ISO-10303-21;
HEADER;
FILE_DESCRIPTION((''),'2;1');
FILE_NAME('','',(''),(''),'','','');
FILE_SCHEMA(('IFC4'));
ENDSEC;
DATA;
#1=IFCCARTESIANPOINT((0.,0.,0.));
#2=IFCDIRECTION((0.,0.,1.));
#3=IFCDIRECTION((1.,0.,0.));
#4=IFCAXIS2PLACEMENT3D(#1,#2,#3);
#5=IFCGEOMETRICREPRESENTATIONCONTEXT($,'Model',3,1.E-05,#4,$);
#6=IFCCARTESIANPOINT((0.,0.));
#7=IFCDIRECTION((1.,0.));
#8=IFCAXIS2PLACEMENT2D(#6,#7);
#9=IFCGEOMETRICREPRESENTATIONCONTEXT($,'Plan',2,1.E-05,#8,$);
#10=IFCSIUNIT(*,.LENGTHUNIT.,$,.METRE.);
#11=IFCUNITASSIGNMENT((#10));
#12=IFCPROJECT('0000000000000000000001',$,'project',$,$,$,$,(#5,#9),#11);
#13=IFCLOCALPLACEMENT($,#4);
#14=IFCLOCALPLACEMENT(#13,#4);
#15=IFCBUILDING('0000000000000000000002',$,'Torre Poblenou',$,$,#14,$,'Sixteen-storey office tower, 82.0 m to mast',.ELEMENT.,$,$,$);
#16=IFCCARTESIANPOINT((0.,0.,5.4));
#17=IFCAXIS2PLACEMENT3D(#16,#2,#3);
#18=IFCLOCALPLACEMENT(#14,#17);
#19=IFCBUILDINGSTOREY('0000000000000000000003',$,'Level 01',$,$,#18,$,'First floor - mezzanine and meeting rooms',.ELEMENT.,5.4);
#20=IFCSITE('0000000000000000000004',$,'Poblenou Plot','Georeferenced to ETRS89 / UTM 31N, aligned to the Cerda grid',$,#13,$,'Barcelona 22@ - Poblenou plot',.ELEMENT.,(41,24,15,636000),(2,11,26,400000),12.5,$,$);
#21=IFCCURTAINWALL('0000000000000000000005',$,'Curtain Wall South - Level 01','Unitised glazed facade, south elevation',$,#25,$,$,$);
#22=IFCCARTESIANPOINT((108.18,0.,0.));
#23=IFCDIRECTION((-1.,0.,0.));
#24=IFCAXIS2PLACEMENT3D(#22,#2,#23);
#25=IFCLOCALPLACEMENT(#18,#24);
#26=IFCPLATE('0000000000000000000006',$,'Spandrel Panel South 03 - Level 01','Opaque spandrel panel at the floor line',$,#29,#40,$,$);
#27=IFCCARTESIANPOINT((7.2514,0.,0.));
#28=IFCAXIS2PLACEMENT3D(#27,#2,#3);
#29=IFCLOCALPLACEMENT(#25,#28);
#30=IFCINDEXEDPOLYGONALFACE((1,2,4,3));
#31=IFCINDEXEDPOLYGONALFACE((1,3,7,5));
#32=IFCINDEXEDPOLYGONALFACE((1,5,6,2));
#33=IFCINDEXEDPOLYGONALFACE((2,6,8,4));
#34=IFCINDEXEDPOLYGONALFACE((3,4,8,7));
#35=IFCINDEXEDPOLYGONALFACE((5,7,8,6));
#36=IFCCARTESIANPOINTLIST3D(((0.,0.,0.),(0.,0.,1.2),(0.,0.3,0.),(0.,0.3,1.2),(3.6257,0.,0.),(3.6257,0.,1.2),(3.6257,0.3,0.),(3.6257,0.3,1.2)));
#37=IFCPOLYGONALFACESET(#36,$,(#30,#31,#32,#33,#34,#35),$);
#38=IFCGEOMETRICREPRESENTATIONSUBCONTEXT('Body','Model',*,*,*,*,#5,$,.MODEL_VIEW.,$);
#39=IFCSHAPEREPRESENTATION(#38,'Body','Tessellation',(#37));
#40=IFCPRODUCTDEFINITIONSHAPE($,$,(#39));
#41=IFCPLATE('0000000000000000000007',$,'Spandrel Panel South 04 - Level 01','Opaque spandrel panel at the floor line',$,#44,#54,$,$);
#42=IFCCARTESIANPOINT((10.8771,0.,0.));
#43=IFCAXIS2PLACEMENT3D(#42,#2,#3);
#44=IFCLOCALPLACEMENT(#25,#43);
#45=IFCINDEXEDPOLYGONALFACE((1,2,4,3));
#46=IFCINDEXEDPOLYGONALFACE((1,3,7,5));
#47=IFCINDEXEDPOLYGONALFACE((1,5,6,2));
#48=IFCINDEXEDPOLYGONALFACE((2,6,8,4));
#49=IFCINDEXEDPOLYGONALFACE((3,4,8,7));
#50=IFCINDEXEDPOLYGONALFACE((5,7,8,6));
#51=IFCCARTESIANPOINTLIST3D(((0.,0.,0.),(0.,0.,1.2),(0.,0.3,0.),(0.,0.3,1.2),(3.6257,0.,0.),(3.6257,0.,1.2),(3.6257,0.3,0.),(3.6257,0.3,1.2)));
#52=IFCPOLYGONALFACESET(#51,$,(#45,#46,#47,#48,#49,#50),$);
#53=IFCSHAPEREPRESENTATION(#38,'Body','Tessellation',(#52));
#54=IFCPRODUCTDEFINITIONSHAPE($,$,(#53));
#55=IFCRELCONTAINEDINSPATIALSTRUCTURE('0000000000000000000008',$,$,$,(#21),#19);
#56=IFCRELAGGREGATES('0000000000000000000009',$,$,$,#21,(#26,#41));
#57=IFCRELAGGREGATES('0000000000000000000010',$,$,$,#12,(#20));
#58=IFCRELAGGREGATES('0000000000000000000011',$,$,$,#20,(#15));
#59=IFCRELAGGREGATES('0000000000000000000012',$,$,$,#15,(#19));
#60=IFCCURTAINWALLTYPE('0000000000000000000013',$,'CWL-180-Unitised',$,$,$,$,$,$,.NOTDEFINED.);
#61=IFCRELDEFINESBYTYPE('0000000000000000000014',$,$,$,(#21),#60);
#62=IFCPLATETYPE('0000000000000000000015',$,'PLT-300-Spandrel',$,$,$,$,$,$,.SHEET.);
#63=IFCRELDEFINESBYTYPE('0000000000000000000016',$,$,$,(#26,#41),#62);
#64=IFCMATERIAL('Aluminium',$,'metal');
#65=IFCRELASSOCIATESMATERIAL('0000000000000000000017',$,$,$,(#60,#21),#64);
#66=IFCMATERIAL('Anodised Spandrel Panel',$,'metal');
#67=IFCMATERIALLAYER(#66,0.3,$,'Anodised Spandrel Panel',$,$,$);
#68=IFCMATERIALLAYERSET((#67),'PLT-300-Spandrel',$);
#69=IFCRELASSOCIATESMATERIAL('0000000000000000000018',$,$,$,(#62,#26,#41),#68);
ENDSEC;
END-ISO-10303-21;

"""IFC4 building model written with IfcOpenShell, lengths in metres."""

from ifc_helpers import new_model, si_unit, frame, origin_with_axes, origin_2d_with_axis, place, context, subcontext, project, spatial, line, indexed_curve, outline, extrude, material, layer, layer_set, layer_usage, type_object, element, aggregate, save


model = new_model("IFC4")

# Units and contexts
model_context = context("Model", 3, precision=1e-05, world=origin_with_axes())
plan_context = context("Plan", 2, precision=1e-05, world=origin_2d_with_axis())
body_context = subcontext(model_context, "Body", "Model", "MODEL_VIEW")
ifc_project = project(units=[si_unit("LENGTHUNIT", "METRE")], contexts=[model_context, plan_context])

# Site, building, storey
site_placement = place(None, origin_with_axes())
site = spatial("IfcSite", under=ifc_project, at=site_placement, Name="Poblenou Plot", Description="Georeferenced to ETRS89 / UTM 31N, aligned to the Cerda grid", LongName="Barcelona 22@ - Poblenou plot", CompositionType="ELEMENT", RefLatitude=(41, 24, 15, 636000), RefLongitude=(2, 11, 26, 400000), RefElevation=12.5)
building_placement = place(site_placement, origin_with_axes())
building = spatial("IfcBuilding", under=site, at=building_placement, Name="Torre Poblenou", LongName="Sixteen-storey office tower, 82.0 m to mast", CompositionType="ELEMENT")
storey_placement = place(building_placement, frame((0.0, 0.0, 5.4), z_axis=(0.0, 0.0, 1.0), x_axis=(1.0, 0.0, 0.0)))
storey = spatial("IfcBuildingStorey", under=building, at=storey_placement, Name="Level 01", LongName="First floor - mezzanine and meeting rooms", CompositionType="ELEMENT", Elevation=5.4)

# Curtain wall
ifc_material_1 = material(Name="Aluminium", Category="metal")
curtain_wall_type = type_object("IfcCurtainWallType", Name="CWL-180-Unitised", PredefinedType="NOTDEFINED", material=ifc_material_1)
curtain_wall_1_placement = place(storey_placement, frame((108.18, 0.0, 0.0), z_axis=(0.0, 0.0, 1.0), x_axis=(-1.0, 0.0, 0.0)))
curtain_wall_1 = element("IfcCurtainWall", 1, at=curtain_wall_1_placement, inside=storey, type_object=curtain_wall_type, material=ifc_material_1, Name="Curtain Wall South - Level 01", Description="Unitised glazed facade, south elevation")

# Plates
ifc_material_2 = material(Name="Anodised Spandrel Panel", Category="metal")
ifc_layer_1 = layer(ifc_material_2, 0.3, Name="Anodised Spandrel Panel")
ifc_layer_set_1 = layer_set([ifc_layer_1], Name="PLT-300-Spandrel")
plate_type_1 = type_object("IfcPlateType", Name="PLT-300-Spandrel", PredefinedType="SHEET", material=ifc_layer_set_1)
ifc_layer_usage_1 = layer_usage(ifc_layer_set_1, "AXIS2", "POSITIVE", 0.0)
plate_1_placement = place(curtain_wall_1_placement, frame((7.2514, 0.0, 0.0), z_axis=(0.0, 0.0, 1.0), x_axis=(1.0, 0.0, 0.0)))
plate_1 = element("IfcPlate", 2, at=plate_1_placement, type_object=plate_type_1, material=ifc_layer_usage_1, Name="Spandrel Panel South 03 - Level 01", Description="Opaque spandrel panel at the floor line", context=body_context, shape_type="SweptSolid", body=[
    extrude(outline(indexed_curve([(0.0, 0.0), (3.6257, 0.0), (3.6257, 0.3), (0.0, 0.3)], segments=[line(1, 2, 3, 4, 1)])), origin_with_axes(), (0.0, 0.0, 1.0), 1.2),
])
ifc_layer_usage_2 = layer_usage(ifc_layer_set_1, "AXIS2", "POSITIVE", 0.0)
plate_2_placement = place(curtain_wall_1_placement, frame((10.8771, 0.0, 0.0), z_axis=(0.0, 0.0, 1.0), x_axis=(1.0, 0.0, 0.0)))
plate_2 = element("IfcPlate", 3, at=plate_2_placement, type_object=plate_type_1, material=ifc_layer_usage_2, Name="Spandrel Panel South 04 - Level 01", Description="Opaque spandrel panel at the floor line", context=body_context, shape_type="SweptSolid", body=[
    extrude(outline(indexed_curve([(0.0, 0.0), (3.6257, 0.0), (3.6257, 0.3), (0.0, 0.3)], segments=[line(1, 2, 3, 4, 1)])), origin_with_axes(), (0.0, 0.0, 1.0), 1.2),
])
aggregate(curtain_wall_1, [plate_1, plate_2])

save(model, "model.ifc")
